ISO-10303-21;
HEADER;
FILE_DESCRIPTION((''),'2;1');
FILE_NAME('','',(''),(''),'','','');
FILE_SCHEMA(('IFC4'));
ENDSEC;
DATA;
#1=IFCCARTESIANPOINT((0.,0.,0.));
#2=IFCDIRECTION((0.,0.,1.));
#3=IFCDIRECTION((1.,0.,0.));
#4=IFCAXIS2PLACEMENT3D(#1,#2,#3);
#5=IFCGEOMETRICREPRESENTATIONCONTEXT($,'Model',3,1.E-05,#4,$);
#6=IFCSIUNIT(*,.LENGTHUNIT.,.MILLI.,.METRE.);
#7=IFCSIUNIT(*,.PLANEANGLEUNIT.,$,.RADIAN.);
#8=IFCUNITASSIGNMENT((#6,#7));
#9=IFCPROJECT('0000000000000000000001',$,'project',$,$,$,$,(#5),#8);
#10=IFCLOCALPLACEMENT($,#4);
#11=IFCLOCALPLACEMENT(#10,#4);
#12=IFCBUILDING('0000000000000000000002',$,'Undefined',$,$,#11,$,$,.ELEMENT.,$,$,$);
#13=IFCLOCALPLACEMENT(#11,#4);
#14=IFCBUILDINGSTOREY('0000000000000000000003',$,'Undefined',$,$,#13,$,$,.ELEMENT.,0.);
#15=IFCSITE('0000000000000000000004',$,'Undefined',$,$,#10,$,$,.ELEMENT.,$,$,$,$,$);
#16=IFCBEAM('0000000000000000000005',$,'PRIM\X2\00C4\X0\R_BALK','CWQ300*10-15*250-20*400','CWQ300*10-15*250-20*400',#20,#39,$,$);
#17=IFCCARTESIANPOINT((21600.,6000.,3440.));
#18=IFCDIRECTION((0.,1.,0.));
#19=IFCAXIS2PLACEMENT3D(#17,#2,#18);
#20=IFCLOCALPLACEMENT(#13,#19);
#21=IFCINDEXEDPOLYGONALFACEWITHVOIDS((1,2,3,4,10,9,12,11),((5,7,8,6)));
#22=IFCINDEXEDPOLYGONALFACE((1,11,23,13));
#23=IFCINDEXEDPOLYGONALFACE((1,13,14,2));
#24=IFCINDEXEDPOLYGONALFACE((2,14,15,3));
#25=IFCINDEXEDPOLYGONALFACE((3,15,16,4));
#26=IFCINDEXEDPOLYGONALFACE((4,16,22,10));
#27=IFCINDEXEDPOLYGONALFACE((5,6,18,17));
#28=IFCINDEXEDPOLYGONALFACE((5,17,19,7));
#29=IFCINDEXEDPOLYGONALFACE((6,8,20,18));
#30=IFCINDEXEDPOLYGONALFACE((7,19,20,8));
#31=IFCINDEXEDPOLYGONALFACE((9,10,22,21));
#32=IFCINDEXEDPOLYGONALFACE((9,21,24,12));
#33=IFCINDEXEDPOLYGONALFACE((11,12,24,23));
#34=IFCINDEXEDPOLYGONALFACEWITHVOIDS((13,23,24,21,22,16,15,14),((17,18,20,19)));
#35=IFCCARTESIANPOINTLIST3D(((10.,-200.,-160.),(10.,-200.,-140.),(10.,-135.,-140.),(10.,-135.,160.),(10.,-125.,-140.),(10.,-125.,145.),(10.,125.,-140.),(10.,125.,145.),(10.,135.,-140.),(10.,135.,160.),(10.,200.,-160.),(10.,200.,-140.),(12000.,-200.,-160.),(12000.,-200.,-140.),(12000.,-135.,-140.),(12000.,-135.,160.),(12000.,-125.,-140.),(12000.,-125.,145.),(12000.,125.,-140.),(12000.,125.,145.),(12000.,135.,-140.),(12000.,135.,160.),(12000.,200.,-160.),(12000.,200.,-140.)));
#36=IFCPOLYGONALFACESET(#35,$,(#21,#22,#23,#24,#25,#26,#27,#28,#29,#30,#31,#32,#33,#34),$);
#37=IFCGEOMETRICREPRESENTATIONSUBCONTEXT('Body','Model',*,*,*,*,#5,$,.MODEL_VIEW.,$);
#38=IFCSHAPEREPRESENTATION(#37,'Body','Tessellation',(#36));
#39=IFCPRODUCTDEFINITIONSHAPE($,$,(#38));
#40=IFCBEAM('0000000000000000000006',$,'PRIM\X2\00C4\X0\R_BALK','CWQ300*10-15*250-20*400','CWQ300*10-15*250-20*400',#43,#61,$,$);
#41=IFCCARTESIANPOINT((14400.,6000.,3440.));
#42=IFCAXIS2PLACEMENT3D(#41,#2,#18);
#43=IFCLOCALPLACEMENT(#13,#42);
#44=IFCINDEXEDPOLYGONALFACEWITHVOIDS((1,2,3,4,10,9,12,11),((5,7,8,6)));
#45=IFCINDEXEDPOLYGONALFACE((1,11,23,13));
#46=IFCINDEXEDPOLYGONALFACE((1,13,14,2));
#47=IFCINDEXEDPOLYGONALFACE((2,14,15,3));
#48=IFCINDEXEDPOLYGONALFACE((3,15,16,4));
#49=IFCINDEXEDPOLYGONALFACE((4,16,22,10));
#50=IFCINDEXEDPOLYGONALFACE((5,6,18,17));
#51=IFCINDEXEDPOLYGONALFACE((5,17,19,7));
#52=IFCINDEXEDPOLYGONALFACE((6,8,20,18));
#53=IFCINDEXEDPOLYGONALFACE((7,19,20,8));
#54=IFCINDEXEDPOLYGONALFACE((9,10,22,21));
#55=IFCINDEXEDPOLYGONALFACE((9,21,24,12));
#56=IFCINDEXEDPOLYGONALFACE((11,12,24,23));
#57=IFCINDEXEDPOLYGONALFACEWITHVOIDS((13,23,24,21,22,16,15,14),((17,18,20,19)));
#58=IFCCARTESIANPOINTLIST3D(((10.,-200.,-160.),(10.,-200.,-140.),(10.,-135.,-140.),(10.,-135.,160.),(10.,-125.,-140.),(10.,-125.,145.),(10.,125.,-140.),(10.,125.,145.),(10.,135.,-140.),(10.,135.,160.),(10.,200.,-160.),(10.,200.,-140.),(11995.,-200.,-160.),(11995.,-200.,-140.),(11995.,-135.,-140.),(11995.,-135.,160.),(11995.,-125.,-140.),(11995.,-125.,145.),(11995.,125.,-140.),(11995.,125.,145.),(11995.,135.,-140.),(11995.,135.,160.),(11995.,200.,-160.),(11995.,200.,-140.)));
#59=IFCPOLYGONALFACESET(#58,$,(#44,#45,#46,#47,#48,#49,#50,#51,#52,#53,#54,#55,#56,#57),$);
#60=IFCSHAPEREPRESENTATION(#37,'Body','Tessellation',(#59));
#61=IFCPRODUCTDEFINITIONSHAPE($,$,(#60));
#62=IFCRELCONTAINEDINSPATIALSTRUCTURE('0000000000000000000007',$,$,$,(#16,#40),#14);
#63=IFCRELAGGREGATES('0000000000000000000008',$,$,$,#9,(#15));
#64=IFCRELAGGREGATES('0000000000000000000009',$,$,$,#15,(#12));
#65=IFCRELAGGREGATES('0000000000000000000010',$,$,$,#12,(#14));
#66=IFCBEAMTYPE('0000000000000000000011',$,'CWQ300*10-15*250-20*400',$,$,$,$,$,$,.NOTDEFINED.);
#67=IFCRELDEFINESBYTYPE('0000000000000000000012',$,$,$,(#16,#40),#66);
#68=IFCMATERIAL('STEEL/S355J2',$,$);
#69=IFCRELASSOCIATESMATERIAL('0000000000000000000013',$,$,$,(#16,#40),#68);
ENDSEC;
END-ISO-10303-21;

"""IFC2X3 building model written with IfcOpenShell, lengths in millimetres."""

from ifc_helpers import new_model, si_unit, frame, origin_with_axes, place, context, subcontext, project, spatial, polyline, outline, extrude, clip, halfspace, material, type_object, element, save


model = new_model("IFC2X3")

# Units and contexts
model_context = context("Model", 3, precision=1e-05, world=origin_with_axes())
body_context = subcontext(model_context, "Body", "Model", "MODEL_VIEW")
ifc_project = project(units=[si_unit("LENGTHUNIT", "METRE", prefix="MILLI"), si_unit("PLANEANGLEUNIT", "RADIAN")], contexts=[model_context])

# Site, building, storey
site_placement = place(None, origin_with_axes())
site = spatial("IfcSite", under=ifc_project, at=site_placement, Name="Undefined", CompositionType="ELEMENT")
building_placement = place(site_placement, origin_with_axes())
building = spatial("IfcBuilding", under=site, at=building_placement, Name="Undefined", CompositionType="ELEMENT")
storey_placement = place(building_placement, origin_with_axes())
storey = spatial("IfcBuildingStorey", under=building, at=storey_placement, Name="Undefined", CompositionType="ELEMENT", Elevation=0.0)

# Shared definitions
ifc_material_1 = material(Name="STEEL/S355J2")

# Beams
beam_type_1 = type_object("IfcBeamType", Name="CWQ300*10-15*250-20*400", PredefinedType="NOTDEFINED")
beam_1_placement = place(storey_placement, frame((21600.0, 6000.0, 3440.0), z_axis=(0.0, 0.0, 1.0), x_axis=(0.0, 1.0, 0.0)))
element("IfcBeam", 1, at=beam_1_placement, inside=storey, type_object=beam_type_1, material=ifc_material_1, Name="PRIMÄR_BALK", Description="CWQ300*10-15*250-20*400", ObjectType="CWQ300*10-15*250-20*400", context=body_context, shape_type="Clipping", body=[
    clip(extrude(outline(polyline([(135.0, 160.0), (135.0, -140.0), (200.0, -140.0), (200.0, -160.0), (-200.0, -160.0), (-200.0, -140.0), (-135.0, -140.0), (-135.0, 160.0), (135.0, 160.0)]), holes=[polyline([(-125.0, -140.0), (125.0, -140.0), (125.0, 145.0), (-125.0, 145.0), (-125.0, -140.0)])]), frame((12000.0, 0.0, 0.0), z_axis=(-1.0, 0.0, 0.0), x_axis=(0.0, -1.0, 0.0)), (0.0, 0.0, 1.0), 11990.0), halfspace(frame((10.0, 0.0, -160.0), z_axis=(1.0, 0.0, 0.0), x_axis=(0.0, 1.0, 0.0)), True)),
])
beam_2_placement = place(storey_placement, frame((14400.0, 6000.0, 3440.0), z_axis=(0.0, 0.0, 1.0), x_axis=(0.0, 1.0, 0.0)))
element("IfcBeam", 2, at=beam_2_placement, inside=storey, type_object=beam_type_1, material=ifc_material_1, Name="PRIMÄR_BALK", Description="CWQ300*10-15*250-20*400", ObjectType="CWQ300*10-15*250-20*400", context=body_context, shape_type="Clipping", body=[
    clip(clip(extrude(outline(polyline([(135.0, 160.0), (135.0, -140.0), (200.0, -140.0), (200.0, -160.0), (-200.0, -160.0), (-200.0, -140.0), (-135.0, -140.0), (-135.0, 160.0), (135.0, 160.0)]), holes=[polyline([(-125.0, -140.0), (125.0, -140.0), (125.0, 145.0), (-125.0, 145.0), (-125.0, -140.0)])]), frame((11995.0, 0.0, 0.0), z_axis=(-1.0, 0.0, 0.0), x_axis=(0.0, -1.0, 0.0)), (0.0, 0.0, 1.0), 11985.0), halfspace(frame((11995.0, 0.0, -160.0), z_axis=(-1.0, 0.0, 0.0), x_axis=(0.0, -1.0, 0.0)), True)), halfspace(frame((10.0, 0.0, -160.0), z_axis=(1.0, 0.0, 0.0), x_axis=(0.0, 1.0, 0.0)), True)),
])

save(model, "model.ifc")
